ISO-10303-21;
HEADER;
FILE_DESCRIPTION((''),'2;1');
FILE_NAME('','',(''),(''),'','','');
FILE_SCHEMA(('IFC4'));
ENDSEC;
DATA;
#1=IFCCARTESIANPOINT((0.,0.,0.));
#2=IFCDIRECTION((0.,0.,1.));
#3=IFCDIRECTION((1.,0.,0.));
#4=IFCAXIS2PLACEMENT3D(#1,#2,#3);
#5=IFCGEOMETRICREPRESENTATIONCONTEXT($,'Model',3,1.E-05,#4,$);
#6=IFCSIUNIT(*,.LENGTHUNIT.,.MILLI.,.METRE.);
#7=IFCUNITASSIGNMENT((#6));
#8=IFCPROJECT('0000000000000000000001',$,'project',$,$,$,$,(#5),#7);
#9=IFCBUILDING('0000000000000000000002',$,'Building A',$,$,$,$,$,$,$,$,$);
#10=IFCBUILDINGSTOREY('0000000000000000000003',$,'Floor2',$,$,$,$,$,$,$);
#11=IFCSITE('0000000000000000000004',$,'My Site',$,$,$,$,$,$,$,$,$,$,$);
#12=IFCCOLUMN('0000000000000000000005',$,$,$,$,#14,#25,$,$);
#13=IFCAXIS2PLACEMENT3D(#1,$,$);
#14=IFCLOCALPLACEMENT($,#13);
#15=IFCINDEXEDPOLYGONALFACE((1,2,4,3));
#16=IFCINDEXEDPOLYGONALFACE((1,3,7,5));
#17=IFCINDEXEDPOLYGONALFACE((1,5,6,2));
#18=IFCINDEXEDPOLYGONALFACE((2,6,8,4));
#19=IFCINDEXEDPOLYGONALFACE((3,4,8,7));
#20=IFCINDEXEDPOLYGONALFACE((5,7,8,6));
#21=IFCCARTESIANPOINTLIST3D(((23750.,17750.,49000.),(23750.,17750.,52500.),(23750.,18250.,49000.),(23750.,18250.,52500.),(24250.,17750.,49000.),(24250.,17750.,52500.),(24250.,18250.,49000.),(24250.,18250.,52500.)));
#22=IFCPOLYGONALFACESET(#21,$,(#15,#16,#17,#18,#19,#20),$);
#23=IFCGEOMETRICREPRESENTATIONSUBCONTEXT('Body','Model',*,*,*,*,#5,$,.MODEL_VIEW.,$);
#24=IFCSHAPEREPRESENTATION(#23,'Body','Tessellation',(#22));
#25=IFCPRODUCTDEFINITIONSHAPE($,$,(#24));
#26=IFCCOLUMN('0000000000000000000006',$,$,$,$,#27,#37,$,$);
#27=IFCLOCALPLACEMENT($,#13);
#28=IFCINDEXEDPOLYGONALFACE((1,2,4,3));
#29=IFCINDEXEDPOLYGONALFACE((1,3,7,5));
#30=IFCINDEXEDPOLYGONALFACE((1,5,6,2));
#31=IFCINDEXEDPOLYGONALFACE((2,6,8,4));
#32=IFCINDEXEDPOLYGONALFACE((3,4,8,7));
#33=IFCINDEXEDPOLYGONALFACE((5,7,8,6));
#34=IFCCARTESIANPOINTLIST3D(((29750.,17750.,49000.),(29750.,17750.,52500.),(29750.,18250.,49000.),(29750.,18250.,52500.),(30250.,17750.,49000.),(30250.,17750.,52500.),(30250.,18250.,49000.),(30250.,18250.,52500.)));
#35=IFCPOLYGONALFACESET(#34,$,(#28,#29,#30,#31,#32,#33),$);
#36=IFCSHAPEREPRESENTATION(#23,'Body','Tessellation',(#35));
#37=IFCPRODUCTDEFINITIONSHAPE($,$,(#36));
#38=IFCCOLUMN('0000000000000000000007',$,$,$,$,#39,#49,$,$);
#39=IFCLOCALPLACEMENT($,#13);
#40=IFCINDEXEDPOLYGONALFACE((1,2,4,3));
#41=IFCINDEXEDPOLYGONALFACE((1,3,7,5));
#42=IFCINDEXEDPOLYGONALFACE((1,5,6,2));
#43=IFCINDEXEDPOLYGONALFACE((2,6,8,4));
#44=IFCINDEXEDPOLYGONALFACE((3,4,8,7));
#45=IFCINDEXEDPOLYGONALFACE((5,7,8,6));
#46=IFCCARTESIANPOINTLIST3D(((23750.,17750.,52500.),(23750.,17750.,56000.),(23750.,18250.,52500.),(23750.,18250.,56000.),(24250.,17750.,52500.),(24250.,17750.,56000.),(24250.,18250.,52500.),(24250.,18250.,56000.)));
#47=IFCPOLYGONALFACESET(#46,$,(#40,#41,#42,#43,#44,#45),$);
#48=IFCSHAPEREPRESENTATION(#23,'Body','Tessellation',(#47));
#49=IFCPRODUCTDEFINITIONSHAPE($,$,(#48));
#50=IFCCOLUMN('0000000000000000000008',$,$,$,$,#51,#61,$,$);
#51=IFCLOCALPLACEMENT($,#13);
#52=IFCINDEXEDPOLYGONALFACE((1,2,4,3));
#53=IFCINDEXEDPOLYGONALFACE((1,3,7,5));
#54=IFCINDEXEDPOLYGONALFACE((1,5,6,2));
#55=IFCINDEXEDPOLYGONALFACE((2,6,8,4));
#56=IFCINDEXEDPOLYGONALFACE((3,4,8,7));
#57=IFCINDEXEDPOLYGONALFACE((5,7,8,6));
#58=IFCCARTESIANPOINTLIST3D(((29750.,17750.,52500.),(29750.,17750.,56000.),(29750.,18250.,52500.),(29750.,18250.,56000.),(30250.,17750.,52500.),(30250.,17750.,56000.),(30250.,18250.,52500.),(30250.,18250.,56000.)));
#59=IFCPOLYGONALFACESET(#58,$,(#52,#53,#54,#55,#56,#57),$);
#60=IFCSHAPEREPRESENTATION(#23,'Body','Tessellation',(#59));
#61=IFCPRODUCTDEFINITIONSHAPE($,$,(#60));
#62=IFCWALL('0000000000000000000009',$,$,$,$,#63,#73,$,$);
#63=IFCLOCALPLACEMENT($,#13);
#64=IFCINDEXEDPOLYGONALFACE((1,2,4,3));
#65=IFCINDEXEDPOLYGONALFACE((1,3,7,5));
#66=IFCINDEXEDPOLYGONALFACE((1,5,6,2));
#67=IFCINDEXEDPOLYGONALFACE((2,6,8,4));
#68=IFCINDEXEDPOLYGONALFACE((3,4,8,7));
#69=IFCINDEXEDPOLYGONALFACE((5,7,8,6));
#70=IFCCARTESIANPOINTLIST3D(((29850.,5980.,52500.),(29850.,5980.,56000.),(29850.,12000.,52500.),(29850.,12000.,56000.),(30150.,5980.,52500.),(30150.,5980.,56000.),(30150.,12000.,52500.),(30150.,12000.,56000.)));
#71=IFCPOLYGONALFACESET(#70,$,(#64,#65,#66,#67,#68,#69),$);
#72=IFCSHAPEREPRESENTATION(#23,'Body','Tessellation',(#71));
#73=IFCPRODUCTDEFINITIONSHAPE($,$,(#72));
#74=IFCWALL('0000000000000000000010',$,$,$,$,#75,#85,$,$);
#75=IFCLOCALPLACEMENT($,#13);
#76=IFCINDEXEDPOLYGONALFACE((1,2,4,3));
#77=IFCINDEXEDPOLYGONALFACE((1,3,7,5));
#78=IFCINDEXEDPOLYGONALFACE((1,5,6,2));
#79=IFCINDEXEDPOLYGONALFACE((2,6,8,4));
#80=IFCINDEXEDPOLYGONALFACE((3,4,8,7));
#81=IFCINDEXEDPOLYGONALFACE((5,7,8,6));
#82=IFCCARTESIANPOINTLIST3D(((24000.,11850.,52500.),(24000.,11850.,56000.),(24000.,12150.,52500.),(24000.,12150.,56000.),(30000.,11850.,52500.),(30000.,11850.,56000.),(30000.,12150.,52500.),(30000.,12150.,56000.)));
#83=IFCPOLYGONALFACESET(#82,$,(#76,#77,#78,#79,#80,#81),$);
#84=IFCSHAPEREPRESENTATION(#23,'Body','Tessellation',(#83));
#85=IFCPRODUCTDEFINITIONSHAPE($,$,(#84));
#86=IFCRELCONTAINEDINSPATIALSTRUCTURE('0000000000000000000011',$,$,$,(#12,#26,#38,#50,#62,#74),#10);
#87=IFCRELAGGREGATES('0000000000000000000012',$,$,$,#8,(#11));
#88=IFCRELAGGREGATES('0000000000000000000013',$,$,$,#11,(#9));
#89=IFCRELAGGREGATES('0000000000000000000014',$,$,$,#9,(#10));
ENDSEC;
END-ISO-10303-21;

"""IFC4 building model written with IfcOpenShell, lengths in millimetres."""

from ifc_helpers import new_model, si_unit, frame, origin_with_axes, place, context, subcontext, project, spatial, line, indexed_curve, outline, extrude, element, save


model = new_model("IFC4")

# Units and contexts
model_context = context("Model", 3, precision=1e-05, world=origin_with_axes())
body_context = subcontext(model_context, "Body", "Model", "MODEL_VIEW")
ifc_project = project(units=[si_unit("LENGTHUNIT", "METRE", prefix="MILLI")], contexts=[model_context])

# Site, building, storey
site = spatial("IfcSite", under=ifc_project, Name="My Site")
building = spatial("IfcBuilding", under=site, Name="Building A")
storey = spatial("IfcBuildingStorey", under=building, Name="Floor2")

# Columns
for number, where, z_axis, x_axis in (
    (1, (24000.0, 18000.0, 49000.0), (0.0, 0.0, 1.0), (1.0, 0.0, 0.0)),
    (2, (30000.0, 18000.0, 49000.0), (0.0, 0.0, 1.0), (1.0, 0.0, 0.0)),
    (3, (24000.0, 18000.0, 52500.0), (0.0, 0.0, 1.0), (1.0, 0.0, 0.0)),
    (4, (30000.0, 18000.0, 52500.0), (0.0, 0.0, 1.0), (1.0, 0.0, 0.0)),
):
    element("IfcColumn", number, at=place(None, frame(where, z_axis=z_axis, x_axis=x_axis)), inside=storey, context=body_context, shape_type="SweptSolid", body=[
        extrude(outline(indexed_curve([(-250.0, -250.0), (250.0, -250.0), (250.0, 250.0), (-250.0, 250.0)], segments=[line(1, 2, 3, 4, 1)])), origin_with_axes(), (0.0, 0.0, 1.0), 3500.0),
    ])

# Walls
wall_1_placement = place(None, frame((29850.0, 12000.0, 52500.0), z_axis=(0.0, 0.0, 1.0), x_axis=(0.0, -1.0, 0.0)))
element("IfcWall", 5, at=wall_1_placement, inside=storey, context=body_context, shape_type="SweptSolid", body=[
    extrude(outline(indexed_curve([(0.0, 0.0), (0.0, 300.0), (6020.0, 300.0), (6020.0, 0.0), (0.0, 0.0)], self_intersect=False)), origin_with_axes(), (0.0, 0.0, 1.0), 3500.0),
])
wall_2_placement = place(None, frame((24000.0, 11850.0, 52500.0), z_axis=(0.0, 0.0, 1.0), x_axis=(1.0, 0.0, 0.0)))
element("IfcWall", 6, at=wall_2_placement, inside=storey, context=body_context, shape_type="SweptSolid", body=[
    extrude(outline(indexed_curve([(0.0, 0.0), (0.0, 300.0), (6000.0, 300.0), (6000.0, 0.0), (0.0, 0.0)], self_intersect=False)), origin_with_axes(), (0.0, 0.0, 1.0), 3500.0),
])

save(model, "model.ifc")
